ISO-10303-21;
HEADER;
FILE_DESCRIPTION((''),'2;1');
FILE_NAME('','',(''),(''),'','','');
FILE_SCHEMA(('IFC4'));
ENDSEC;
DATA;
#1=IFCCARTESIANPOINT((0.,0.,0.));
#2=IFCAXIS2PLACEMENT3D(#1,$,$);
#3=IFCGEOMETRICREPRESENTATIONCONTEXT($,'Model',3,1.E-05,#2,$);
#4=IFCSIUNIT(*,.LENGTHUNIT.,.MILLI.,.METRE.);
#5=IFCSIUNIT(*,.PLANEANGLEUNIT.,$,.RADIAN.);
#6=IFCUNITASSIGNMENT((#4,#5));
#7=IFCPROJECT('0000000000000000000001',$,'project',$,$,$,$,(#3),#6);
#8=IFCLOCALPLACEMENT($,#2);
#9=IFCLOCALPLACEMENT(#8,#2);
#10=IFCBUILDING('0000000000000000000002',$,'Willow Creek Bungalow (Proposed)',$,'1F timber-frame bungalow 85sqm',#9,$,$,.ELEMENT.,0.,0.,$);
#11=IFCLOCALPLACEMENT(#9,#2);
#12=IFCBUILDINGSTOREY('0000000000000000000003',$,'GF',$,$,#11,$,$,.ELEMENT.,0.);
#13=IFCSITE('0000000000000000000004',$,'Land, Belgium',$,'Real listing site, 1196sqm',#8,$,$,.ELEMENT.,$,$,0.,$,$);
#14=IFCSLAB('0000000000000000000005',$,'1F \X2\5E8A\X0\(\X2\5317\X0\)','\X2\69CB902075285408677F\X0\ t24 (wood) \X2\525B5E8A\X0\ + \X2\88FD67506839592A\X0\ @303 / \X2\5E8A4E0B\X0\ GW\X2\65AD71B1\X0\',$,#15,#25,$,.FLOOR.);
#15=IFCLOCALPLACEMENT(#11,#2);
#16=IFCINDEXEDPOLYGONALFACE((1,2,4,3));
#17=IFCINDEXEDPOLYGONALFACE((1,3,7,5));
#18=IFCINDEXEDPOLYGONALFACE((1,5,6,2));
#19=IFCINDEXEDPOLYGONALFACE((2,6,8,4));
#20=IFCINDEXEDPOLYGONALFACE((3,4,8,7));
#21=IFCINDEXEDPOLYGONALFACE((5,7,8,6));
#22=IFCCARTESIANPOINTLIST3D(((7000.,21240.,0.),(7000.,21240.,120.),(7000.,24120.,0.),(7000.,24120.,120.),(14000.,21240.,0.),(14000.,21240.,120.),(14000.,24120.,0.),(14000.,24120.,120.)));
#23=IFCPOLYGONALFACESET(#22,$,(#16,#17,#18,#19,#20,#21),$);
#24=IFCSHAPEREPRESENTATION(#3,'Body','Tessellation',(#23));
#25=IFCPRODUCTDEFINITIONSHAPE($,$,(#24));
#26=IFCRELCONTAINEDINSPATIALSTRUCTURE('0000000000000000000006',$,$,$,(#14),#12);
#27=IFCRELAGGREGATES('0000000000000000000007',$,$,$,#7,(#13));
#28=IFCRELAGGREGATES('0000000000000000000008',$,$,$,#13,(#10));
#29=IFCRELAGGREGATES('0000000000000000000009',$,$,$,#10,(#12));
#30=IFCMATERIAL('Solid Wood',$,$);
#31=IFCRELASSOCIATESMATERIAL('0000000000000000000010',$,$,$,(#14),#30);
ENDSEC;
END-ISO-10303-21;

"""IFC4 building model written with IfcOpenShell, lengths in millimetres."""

from ifc_helpers import new_model, si_unit, frame, frame_2d, origin, place, context, project, spatial, rectangle, extrude, material, element, save


model = new_model("IFC4")

# Units and contexts
model_context = context("Model", 3, precision=1e-05, world=origin())
ifc_project = project(units=[si_unit("LENGTHUNIT", "METRE", prefix="MILLI"), si_unit("PLANEANGLEUNIT", "RADIAN")], contexts=[model_context])

# Site, building, storey
site_placement = place(None, origin())
site = spatial("IfcSite", under=ifc_project, at=site_placement, Name="Land, Belgium", ObjectType="Real listing site, 1196sqm", CompositionType="ELEMENT", RefElevation=0.0)
building_placement = place(site_placement, origin())
building = spatial("IfcBuilding", under=site, at=building_placement, Name="Willow Creek Bungalow (Proposed)", ObjectType="1F timber-frame bungalow 85sqm", CompositionType="ELEMENT", ElevationOfRefHeight=0.0, ElevationOfTerrain=0.0)
storey_placement = place(building_placement, origin())
storey = spatial("IfcBuildingStorey", under=building, at=storey_placement, Name="GF", CompositionType="ELEMENT", Elevation=0.0)

# Slab
ifc_material_1 = material(Name="Solid Wood")
slab_1_placement = place(storey_placement, frame((3500.0, 10620.0, 0.0)))
element("IfcSlab", 1, at=slab_1_placement, inside=storey, material=ifc_material_1, Name="1F 床(北)", Description="構造用合板 t24 (wood) 剛床 + 製材根太 @303 / 床下 GW断熱", PredefinedType="FLOOR", context=model_context, shape_type="SweptSolid", body=[
    extrude(rectangle(XDim=7000.0, YDim=2880.0, at=frame_2d((3500.0, 1440.0))), frame((3500.0, 10620.0, 0.0)), (0.0, 0.0, 1.0), 120.0),
])

save(model, "model.ifc")
